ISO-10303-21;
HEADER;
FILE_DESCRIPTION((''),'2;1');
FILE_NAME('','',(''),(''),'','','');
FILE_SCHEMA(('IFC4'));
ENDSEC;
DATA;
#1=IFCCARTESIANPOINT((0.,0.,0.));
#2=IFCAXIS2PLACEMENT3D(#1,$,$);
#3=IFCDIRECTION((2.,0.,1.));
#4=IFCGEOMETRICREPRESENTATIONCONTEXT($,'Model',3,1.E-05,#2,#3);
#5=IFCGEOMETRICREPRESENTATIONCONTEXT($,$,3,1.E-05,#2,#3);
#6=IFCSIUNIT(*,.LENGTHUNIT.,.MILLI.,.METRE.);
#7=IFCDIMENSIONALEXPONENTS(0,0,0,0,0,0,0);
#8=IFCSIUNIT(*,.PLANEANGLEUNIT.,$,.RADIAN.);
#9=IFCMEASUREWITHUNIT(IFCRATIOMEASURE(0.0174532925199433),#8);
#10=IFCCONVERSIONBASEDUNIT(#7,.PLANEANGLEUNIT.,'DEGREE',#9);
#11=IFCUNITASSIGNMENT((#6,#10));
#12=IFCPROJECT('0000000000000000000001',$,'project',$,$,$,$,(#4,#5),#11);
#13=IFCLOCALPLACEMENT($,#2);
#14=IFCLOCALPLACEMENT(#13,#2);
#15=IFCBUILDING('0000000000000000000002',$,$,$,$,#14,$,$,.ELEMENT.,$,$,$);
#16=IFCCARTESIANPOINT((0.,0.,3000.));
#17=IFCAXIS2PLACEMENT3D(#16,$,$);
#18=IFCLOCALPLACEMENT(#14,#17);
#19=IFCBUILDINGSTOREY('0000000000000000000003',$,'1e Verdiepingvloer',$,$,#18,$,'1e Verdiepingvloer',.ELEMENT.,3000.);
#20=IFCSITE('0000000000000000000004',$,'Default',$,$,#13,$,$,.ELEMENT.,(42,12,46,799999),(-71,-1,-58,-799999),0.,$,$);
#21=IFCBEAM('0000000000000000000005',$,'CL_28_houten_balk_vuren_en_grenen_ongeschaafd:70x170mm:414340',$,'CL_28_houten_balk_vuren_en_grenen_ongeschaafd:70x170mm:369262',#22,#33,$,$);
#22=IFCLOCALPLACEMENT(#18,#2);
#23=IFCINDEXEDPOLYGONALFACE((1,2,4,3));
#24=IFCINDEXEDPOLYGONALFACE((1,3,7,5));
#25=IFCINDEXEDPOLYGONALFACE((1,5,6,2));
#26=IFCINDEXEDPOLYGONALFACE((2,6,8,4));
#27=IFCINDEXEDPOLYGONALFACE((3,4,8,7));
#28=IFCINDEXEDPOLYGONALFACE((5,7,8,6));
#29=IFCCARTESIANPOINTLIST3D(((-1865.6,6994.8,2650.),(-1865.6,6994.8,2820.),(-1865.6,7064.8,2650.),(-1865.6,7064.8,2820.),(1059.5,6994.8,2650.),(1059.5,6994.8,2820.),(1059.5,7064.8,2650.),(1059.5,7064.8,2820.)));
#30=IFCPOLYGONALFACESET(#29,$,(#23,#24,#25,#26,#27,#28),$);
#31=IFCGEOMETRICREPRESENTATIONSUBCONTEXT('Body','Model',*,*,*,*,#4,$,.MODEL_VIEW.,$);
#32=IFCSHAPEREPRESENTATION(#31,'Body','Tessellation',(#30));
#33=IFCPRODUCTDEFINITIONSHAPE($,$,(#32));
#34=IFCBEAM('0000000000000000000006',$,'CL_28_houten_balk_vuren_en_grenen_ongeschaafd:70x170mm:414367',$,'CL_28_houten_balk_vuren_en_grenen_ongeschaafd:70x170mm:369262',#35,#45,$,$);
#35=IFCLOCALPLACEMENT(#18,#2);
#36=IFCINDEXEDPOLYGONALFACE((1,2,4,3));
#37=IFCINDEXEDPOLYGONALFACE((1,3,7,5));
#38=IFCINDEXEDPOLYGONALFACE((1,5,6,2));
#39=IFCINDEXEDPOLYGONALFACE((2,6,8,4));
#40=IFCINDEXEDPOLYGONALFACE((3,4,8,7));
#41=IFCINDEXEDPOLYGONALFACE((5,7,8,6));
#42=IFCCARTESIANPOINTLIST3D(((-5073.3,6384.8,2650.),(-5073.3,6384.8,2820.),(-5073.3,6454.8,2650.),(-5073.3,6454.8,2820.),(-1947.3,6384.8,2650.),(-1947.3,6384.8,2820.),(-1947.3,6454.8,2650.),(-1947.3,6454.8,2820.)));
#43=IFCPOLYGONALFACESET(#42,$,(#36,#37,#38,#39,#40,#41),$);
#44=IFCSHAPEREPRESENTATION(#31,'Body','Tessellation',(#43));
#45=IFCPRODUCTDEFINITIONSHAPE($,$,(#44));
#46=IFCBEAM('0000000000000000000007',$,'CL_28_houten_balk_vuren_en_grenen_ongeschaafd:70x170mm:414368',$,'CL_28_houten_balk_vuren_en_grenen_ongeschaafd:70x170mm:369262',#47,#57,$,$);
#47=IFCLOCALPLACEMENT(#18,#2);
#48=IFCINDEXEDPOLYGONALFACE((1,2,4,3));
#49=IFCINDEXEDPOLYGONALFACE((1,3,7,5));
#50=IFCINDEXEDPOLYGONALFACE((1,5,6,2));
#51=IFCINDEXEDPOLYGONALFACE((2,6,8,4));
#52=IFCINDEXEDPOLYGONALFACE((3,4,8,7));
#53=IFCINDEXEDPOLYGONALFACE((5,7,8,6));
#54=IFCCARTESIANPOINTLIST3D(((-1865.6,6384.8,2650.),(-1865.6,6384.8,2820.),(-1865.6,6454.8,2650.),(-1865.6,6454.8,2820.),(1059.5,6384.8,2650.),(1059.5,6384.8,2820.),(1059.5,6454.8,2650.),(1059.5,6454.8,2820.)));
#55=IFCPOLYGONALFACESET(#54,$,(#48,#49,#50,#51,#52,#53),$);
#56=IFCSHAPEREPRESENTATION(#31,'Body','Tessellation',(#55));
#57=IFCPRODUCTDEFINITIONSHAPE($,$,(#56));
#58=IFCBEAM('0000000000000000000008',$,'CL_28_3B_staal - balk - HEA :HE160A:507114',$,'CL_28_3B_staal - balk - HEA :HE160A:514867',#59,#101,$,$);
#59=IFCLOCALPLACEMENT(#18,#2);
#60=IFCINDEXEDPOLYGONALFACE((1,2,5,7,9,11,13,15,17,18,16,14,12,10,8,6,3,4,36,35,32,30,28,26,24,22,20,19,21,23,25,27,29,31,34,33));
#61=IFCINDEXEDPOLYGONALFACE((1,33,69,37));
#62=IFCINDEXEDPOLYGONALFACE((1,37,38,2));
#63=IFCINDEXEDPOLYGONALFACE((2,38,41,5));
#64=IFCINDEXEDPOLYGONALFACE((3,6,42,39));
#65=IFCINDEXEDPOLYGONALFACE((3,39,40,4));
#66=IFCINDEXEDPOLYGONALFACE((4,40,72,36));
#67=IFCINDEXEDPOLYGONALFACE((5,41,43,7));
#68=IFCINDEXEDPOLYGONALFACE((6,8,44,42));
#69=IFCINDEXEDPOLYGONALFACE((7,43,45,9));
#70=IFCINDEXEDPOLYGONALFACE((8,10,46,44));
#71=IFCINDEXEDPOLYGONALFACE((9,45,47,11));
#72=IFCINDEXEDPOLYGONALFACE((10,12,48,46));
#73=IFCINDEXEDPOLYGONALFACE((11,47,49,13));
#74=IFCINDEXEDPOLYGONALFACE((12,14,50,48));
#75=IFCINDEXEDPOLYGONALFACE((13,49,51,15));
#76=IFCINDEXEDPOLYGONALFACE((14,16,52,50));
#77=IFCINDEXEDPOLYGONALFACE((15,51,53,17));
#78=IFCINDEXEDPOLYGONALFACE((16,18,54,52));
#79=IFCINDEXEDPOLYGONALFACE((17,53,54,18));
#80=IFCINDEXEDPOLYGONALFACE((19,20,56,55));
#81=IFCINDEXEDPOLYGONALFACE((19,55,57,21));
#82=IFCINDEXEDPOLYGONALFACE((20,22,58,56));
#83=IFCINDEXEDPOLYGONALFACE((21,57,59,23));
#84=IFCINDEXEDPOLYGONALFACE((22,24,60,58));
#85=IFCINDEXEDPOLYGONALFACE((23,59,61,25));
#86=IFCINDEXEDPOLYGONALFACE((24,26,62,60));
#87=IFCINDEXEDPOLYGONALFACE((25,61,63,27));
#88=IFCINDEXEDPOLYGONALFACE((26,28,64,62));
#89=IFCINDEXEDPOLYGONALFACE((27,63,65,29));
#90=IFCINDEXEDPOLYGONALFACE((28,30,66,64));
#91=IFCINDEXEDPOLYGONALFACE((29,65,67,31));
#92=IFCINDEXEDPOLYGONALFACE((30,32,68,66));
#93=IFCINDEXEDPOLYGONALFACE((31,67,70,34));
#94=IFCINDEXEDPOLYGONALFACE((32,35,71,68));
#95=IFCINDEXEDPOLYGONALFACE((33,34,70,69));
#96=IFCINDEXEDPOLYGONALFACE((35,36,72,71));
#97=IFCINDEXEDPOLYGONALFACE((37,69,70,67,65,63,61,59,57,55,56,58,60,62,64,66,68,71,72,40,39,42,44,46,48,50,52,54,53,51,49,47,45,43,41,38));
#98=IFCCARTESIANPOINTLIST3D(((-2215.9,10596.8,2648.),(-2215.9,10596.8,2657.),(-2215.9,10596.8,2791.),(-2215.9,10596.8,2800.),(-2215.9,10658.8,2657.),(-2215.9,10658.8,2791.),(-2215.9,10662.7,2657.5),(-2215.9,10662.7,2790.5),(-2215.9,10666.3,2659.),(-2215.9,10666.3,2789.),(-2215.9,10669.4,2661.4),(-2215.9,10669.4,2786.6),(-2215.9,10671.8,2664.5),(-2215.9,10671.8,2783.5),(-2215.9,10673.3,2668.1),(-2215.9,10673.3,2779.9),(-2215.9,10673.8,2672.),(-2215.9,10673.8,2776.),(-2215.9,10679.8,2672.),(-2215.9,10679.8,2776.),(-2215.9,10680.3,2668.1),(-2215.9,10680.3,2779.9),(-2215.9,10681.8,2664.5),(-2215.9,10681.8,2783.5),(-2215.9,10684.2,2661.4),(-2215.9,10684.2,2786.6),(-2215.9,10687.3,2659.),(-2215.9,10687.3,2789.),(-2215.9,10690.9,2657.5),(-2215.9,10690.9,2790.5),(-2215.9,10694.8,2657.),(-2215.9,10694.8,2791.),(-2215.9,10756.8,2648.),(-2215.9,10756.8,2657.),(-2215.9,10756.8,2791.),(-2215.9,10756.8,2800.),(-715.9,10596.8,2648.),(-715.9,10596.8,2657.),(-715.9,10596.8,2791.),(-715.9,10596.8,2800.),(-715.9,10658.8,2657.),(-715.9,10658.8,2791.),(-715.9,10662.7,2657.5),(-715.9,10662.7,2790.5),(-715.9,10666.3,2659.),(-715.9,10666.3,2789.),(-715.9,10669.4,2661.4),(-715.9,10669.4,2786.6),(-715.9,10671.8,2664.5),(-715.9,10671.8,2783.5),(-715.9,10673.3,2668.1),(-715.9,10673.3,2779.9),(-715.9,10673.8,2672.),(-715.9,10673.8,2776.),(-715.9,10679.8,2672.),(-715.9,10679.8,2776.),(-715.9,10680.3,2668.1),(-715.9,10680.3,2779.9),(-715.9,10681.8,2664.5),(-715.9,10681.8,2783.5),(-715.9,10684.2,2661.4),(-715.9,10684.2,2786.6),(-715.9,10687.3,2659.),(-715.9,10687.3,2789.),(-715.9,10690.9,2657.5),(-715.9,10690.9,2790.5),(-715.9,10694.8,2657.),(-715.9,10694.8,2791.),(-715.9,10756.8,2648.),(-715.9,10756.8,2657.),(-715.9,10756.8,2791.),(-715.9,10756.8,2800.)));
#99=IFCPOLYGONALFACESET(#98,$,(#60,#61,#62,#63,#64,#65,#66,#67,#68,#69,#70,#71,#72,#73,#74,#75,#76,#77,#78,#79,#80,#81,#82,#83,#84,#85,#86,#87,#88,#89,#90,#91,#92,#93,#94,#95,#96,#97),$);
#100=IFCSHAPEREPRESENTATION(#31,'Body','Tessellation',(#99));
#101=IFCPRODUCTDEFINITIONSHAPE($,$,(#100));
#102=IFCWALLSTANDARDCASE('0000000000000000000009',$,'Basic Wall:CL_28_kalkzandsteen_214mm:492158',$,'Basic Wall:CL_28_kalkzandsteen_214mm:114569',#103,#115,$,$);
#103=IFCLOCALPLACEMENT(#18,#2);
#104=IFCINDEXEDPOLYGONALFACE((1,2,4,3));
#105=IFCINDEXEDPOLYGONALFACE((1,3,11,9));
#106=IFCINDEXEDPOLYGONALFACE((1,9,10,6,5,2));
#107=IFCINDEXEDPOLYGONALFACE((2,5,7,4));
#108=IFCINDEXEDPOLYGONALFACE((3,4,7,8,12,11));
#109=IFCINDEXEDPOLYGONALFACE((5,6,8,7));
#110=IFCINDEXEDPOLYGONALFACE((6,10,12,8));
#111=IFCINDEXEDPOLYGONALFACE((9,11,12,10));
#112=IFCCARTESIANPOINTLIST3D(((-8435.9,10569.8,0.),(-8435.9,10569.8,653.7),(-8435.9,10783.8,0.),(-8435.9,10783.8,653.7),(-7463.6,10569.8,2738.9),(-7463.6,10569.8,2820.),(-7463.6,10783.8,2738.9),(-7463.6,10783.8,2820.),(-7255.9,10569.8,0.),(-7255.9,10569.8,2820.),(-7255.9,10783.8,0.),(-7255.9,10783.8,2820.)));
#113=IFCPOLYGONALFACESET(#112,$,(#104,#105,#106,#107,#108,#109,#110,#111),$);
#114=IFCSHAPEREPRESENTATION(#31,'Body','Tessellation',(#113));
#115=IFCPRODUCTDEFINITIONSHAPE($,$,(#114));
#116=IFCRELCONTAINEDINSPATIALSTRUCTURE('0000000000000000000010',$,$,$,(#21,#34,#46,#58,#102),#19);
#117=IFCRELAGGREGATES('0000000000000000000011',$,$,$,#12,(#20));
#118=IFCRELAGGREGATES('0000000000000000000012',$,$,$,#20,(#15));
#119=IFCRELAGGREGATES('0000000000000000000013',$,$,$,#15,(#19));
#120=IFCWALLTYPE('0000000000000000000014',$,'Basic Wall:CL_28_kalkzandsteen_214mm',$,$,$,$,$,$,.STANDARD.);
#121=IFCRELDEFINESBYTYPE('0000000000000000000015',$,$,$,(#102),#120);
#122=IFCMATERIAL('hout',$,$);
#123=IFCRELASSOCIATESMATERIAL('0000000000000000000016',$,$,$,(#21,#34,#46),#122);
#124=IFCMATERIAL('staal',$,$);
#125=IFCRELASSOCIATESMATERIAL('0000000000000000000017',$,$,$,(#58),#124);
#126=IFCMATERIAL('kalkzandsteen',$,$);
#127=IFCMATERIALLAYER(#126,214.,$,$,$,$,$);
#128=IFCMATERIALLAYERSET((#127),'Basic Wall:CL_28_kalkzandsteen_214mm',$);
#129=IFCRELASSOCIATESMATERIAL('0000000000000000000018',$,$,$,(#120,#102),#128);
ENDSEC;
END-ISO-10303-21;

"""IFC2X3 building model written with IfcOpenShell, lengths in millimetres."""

from ifc_helpers import new_model, entity, si_unit, converted_unit, direction, frame, frame_2d, origin, place, context, subcontext, project, spatial, polyline, rectangle, i_section, extrude, clip, bounded_halfspace, material, layer, layer_set, layer_usage, type_object, element, save


model = new_model("IFC2X3")

# Units and contexts
model_context = context("Model", 3, precision=1e-05, world=origin(), true_north=direction((2.0, 0.0, 1.0)))
context_of_model = context(None, 3, precision=1e-05, world=origin(), true_north=direction((2.0, 0.0, 1.0)))
body_context = subcontext(model_context, "Body", "Model", "MODEL_VIEW")
ifc_project = project(units=[si_unit("LENGTHUNIT", "METRE", prefix="MILLI"), converted_unit("PLANEANGLEUNIT", "DEGREE", entity("IfcRatioMeasure", 0.0174532925199433), si_unit("PLANEANGLEUNIT", "RADIAN"), dimensions=[0, 0, 0, 0, 0, 0, 0])], contexts=[model_context, context_of_model])

# Site, building, storey
site_placement = place(None, origin())
site = spatial("IfcSite", under=ifc_project, at=site_placement, Name="Default", CompositionType="ELEMENT", RefLatitude=(42, 12, 46, 799999), RefLongitude=(-71, -1, -58, -799999), RefElevation=0.0)
building_placement = place(site_placement, origin())
building = spatial("IfcBuilding", under=site, at=building_placement, CompositionType="ELEMENT")
storey_placement = place(building_placement, frame((0.0, 0.0, 3000.0)))
storey = spatial("IfcBuildingStorey", under=building, at=storey_placement, Name="1e Verdiepingvloer", LongName="1e Verdiepingvloer", CompositionType="ELEMENT", Elevation=3000.0)

# Beams
ifc_material_1 = material(Name="staal")
ifc_material_2 = material(Name="hout")
beam_1_placement = place(storey_placement, frame((-2128.9, 7029.8, 2820.0)))
element("IfcBeam", 1, at=beam_1_placement, inside=storey, material=ifc_material_2, Name="CL_28_houten_balk_vuren_en_grenen_ongeschaafd:70x170mm:414340", ObjectType="CL_28_houten_balk_vuren_en_grenen_ongeschaafd:70x170mm:369262", context=body_context, shape_type="SweptSolid", body=[
    extrude(rectangle(XDim=170.0, YDim=70.0, at=frame_2d((0.0, 0.0), x_axis=(1.0, 0.0))), frame((263.4, 0.0, -85.0), z_axis=(1.0, 0.0, 0.0), x_axis=(0.0, 0.0, -1.0)), (0.0, 0.0, 1.0), 2925.0),
])
beam_2_placement = place(storey_placement, frame((-5228.9, 6419.8, 2820.0)))
element("IfcBeam", 2, at=beam_2_placement, inside=storey, material=ifc_material_2, Name="CL_28_houten_balk_vuren_en_grenen_ongeschaafd:70x170mm:414367", ObjectType="CL_28_houten_balk_vuren_en_grenen_ongeschaafd:70x170mm:369262", context=body_context, shape_type="SweptSolid", body=[
    extrude(rectangle(XDim=170.0, YDim=70.0, at=frame_2d((0.0, 0.0), x_axis=(1.0, 0.0))), frame((155.6, 0.0, -85.0), z_axis=(1.0, 0.0, 0.0), x_axis=(0.0, 0.0, -1.0)), (0.0, 0.0, 1.0), 3126.0),
])
beam_3_placement = place(storey_placement, frame((-2128.9, 6419.8, 2820.0)))
element("IfcBeam", 3, at=beam_3_placement, inside=storey, material=ifc_material_2, Name="CL_28_houten_balk_vuren_en_grenen_ongeschaafd:70x170mm:414368", ObjectType="CL_28_houten_balk_vuren_en_grenen_ongeschaafd:70x170mm:369262", context=body_context, shape_type="SweptSolid", body=[
    extrude(rectangle(XDim=170.0, YDim=70.0, at=frame_2d((0.0, 0.0), x_axis=(1.0, 0.0))), frame((263.4, 0.0, -85.0), z_axis=(1.0, 0.0, 0.0), x_axis=(0.0, 0.0, -1.0)), (0.0, 0.0, 1.0), 2925.0),
])
beam_4_placement = place(storey_placement, frame((-2215.9, 10676.8, 2800.0)))
element("IfcBeam", 4, at=beam_4_placement, inside=storey, material=ifc_material_1, Name="CL_28_3B_staal - balk - HEA :HE160A:507114", ObjectType="CL_28_3B_staal - balk - HEA :HE160A:514867", context=body_context, shape_type="SweptSolid", body=[
    extrude(i_section(OverallWidth=160.0, OverallDepth=152.0, WebThickness=6.0, FlangeThickness=9.0, FilletRadius=15.0, at=frame_2d((0.0, 0.0), x_axis=(0.0, 1.0))), frame((0.0, 0.0, -76.0), z_axis=(1.0, 0.0, 0.0), x_axis=(0.0, 0.0, -1.0)), (0.0, 0.0, 1.0), 1500.0),
])

# Wall
ifc_material_3 = material(Name="kalkzandsteen")
ifc_layer = layer(ifc_material_3, 214.0)
ifc_layer_set = layer_set([ifc_layer], Name="Basic Wall:CL_28_kalkzandsteen_214mm")
ifc_layer_usage = layer_usage(ifc_layer_set, "AXIS2", "NEGATIVE", 107.0)
wall_type = type_object("IfcWallType", Name="Basic Wall:CL_28_kalkzandsteen_214mm", PredefinedType="STANDARD", material=ifc_layer_set)
wall_placement = place(storey_placement, frame((-7255.9, 10676.8, 0.0), z_axis=(0.0, 0.0, 1.0), x_axis=(-1.0, 0.0, 0.0)))
element("IfcWallStandardCase", 5, at=wall_placement, inside=storey, type_object=wall_type, material=ifc_layer_usage, Name="Basic Wall:CL_28_kalkzandsteen_214mm:492158", ObjectType="Basic Wall:CL_28_kalkzandsteen_214mm:114569", context=body_context, shape_type="Clipping", body=[
    clip(extrude(rectangle(XDim=1180.0, YDim=214.0, at=frame_2d((590.0, 0.0), x_axis=(-1.0, 0.0))), origin(), (0.0, 0.0, 1.0), 2820.0), bounded_halfspace(frame((207.7, -107.0, 2738.9), z_axis=(0.906308, 0.0, 0.422618), x_axis=(0.0, 1.0, 0.0)), False, frame((207.7, -107.0, 2738.9)), polyline([(0.0, 0.0), (972.3, 0.0), (972.3, 214.0), (0.0, 214.0), (0.0, 0.0)]))),
])

save(model, "model.ifc")
